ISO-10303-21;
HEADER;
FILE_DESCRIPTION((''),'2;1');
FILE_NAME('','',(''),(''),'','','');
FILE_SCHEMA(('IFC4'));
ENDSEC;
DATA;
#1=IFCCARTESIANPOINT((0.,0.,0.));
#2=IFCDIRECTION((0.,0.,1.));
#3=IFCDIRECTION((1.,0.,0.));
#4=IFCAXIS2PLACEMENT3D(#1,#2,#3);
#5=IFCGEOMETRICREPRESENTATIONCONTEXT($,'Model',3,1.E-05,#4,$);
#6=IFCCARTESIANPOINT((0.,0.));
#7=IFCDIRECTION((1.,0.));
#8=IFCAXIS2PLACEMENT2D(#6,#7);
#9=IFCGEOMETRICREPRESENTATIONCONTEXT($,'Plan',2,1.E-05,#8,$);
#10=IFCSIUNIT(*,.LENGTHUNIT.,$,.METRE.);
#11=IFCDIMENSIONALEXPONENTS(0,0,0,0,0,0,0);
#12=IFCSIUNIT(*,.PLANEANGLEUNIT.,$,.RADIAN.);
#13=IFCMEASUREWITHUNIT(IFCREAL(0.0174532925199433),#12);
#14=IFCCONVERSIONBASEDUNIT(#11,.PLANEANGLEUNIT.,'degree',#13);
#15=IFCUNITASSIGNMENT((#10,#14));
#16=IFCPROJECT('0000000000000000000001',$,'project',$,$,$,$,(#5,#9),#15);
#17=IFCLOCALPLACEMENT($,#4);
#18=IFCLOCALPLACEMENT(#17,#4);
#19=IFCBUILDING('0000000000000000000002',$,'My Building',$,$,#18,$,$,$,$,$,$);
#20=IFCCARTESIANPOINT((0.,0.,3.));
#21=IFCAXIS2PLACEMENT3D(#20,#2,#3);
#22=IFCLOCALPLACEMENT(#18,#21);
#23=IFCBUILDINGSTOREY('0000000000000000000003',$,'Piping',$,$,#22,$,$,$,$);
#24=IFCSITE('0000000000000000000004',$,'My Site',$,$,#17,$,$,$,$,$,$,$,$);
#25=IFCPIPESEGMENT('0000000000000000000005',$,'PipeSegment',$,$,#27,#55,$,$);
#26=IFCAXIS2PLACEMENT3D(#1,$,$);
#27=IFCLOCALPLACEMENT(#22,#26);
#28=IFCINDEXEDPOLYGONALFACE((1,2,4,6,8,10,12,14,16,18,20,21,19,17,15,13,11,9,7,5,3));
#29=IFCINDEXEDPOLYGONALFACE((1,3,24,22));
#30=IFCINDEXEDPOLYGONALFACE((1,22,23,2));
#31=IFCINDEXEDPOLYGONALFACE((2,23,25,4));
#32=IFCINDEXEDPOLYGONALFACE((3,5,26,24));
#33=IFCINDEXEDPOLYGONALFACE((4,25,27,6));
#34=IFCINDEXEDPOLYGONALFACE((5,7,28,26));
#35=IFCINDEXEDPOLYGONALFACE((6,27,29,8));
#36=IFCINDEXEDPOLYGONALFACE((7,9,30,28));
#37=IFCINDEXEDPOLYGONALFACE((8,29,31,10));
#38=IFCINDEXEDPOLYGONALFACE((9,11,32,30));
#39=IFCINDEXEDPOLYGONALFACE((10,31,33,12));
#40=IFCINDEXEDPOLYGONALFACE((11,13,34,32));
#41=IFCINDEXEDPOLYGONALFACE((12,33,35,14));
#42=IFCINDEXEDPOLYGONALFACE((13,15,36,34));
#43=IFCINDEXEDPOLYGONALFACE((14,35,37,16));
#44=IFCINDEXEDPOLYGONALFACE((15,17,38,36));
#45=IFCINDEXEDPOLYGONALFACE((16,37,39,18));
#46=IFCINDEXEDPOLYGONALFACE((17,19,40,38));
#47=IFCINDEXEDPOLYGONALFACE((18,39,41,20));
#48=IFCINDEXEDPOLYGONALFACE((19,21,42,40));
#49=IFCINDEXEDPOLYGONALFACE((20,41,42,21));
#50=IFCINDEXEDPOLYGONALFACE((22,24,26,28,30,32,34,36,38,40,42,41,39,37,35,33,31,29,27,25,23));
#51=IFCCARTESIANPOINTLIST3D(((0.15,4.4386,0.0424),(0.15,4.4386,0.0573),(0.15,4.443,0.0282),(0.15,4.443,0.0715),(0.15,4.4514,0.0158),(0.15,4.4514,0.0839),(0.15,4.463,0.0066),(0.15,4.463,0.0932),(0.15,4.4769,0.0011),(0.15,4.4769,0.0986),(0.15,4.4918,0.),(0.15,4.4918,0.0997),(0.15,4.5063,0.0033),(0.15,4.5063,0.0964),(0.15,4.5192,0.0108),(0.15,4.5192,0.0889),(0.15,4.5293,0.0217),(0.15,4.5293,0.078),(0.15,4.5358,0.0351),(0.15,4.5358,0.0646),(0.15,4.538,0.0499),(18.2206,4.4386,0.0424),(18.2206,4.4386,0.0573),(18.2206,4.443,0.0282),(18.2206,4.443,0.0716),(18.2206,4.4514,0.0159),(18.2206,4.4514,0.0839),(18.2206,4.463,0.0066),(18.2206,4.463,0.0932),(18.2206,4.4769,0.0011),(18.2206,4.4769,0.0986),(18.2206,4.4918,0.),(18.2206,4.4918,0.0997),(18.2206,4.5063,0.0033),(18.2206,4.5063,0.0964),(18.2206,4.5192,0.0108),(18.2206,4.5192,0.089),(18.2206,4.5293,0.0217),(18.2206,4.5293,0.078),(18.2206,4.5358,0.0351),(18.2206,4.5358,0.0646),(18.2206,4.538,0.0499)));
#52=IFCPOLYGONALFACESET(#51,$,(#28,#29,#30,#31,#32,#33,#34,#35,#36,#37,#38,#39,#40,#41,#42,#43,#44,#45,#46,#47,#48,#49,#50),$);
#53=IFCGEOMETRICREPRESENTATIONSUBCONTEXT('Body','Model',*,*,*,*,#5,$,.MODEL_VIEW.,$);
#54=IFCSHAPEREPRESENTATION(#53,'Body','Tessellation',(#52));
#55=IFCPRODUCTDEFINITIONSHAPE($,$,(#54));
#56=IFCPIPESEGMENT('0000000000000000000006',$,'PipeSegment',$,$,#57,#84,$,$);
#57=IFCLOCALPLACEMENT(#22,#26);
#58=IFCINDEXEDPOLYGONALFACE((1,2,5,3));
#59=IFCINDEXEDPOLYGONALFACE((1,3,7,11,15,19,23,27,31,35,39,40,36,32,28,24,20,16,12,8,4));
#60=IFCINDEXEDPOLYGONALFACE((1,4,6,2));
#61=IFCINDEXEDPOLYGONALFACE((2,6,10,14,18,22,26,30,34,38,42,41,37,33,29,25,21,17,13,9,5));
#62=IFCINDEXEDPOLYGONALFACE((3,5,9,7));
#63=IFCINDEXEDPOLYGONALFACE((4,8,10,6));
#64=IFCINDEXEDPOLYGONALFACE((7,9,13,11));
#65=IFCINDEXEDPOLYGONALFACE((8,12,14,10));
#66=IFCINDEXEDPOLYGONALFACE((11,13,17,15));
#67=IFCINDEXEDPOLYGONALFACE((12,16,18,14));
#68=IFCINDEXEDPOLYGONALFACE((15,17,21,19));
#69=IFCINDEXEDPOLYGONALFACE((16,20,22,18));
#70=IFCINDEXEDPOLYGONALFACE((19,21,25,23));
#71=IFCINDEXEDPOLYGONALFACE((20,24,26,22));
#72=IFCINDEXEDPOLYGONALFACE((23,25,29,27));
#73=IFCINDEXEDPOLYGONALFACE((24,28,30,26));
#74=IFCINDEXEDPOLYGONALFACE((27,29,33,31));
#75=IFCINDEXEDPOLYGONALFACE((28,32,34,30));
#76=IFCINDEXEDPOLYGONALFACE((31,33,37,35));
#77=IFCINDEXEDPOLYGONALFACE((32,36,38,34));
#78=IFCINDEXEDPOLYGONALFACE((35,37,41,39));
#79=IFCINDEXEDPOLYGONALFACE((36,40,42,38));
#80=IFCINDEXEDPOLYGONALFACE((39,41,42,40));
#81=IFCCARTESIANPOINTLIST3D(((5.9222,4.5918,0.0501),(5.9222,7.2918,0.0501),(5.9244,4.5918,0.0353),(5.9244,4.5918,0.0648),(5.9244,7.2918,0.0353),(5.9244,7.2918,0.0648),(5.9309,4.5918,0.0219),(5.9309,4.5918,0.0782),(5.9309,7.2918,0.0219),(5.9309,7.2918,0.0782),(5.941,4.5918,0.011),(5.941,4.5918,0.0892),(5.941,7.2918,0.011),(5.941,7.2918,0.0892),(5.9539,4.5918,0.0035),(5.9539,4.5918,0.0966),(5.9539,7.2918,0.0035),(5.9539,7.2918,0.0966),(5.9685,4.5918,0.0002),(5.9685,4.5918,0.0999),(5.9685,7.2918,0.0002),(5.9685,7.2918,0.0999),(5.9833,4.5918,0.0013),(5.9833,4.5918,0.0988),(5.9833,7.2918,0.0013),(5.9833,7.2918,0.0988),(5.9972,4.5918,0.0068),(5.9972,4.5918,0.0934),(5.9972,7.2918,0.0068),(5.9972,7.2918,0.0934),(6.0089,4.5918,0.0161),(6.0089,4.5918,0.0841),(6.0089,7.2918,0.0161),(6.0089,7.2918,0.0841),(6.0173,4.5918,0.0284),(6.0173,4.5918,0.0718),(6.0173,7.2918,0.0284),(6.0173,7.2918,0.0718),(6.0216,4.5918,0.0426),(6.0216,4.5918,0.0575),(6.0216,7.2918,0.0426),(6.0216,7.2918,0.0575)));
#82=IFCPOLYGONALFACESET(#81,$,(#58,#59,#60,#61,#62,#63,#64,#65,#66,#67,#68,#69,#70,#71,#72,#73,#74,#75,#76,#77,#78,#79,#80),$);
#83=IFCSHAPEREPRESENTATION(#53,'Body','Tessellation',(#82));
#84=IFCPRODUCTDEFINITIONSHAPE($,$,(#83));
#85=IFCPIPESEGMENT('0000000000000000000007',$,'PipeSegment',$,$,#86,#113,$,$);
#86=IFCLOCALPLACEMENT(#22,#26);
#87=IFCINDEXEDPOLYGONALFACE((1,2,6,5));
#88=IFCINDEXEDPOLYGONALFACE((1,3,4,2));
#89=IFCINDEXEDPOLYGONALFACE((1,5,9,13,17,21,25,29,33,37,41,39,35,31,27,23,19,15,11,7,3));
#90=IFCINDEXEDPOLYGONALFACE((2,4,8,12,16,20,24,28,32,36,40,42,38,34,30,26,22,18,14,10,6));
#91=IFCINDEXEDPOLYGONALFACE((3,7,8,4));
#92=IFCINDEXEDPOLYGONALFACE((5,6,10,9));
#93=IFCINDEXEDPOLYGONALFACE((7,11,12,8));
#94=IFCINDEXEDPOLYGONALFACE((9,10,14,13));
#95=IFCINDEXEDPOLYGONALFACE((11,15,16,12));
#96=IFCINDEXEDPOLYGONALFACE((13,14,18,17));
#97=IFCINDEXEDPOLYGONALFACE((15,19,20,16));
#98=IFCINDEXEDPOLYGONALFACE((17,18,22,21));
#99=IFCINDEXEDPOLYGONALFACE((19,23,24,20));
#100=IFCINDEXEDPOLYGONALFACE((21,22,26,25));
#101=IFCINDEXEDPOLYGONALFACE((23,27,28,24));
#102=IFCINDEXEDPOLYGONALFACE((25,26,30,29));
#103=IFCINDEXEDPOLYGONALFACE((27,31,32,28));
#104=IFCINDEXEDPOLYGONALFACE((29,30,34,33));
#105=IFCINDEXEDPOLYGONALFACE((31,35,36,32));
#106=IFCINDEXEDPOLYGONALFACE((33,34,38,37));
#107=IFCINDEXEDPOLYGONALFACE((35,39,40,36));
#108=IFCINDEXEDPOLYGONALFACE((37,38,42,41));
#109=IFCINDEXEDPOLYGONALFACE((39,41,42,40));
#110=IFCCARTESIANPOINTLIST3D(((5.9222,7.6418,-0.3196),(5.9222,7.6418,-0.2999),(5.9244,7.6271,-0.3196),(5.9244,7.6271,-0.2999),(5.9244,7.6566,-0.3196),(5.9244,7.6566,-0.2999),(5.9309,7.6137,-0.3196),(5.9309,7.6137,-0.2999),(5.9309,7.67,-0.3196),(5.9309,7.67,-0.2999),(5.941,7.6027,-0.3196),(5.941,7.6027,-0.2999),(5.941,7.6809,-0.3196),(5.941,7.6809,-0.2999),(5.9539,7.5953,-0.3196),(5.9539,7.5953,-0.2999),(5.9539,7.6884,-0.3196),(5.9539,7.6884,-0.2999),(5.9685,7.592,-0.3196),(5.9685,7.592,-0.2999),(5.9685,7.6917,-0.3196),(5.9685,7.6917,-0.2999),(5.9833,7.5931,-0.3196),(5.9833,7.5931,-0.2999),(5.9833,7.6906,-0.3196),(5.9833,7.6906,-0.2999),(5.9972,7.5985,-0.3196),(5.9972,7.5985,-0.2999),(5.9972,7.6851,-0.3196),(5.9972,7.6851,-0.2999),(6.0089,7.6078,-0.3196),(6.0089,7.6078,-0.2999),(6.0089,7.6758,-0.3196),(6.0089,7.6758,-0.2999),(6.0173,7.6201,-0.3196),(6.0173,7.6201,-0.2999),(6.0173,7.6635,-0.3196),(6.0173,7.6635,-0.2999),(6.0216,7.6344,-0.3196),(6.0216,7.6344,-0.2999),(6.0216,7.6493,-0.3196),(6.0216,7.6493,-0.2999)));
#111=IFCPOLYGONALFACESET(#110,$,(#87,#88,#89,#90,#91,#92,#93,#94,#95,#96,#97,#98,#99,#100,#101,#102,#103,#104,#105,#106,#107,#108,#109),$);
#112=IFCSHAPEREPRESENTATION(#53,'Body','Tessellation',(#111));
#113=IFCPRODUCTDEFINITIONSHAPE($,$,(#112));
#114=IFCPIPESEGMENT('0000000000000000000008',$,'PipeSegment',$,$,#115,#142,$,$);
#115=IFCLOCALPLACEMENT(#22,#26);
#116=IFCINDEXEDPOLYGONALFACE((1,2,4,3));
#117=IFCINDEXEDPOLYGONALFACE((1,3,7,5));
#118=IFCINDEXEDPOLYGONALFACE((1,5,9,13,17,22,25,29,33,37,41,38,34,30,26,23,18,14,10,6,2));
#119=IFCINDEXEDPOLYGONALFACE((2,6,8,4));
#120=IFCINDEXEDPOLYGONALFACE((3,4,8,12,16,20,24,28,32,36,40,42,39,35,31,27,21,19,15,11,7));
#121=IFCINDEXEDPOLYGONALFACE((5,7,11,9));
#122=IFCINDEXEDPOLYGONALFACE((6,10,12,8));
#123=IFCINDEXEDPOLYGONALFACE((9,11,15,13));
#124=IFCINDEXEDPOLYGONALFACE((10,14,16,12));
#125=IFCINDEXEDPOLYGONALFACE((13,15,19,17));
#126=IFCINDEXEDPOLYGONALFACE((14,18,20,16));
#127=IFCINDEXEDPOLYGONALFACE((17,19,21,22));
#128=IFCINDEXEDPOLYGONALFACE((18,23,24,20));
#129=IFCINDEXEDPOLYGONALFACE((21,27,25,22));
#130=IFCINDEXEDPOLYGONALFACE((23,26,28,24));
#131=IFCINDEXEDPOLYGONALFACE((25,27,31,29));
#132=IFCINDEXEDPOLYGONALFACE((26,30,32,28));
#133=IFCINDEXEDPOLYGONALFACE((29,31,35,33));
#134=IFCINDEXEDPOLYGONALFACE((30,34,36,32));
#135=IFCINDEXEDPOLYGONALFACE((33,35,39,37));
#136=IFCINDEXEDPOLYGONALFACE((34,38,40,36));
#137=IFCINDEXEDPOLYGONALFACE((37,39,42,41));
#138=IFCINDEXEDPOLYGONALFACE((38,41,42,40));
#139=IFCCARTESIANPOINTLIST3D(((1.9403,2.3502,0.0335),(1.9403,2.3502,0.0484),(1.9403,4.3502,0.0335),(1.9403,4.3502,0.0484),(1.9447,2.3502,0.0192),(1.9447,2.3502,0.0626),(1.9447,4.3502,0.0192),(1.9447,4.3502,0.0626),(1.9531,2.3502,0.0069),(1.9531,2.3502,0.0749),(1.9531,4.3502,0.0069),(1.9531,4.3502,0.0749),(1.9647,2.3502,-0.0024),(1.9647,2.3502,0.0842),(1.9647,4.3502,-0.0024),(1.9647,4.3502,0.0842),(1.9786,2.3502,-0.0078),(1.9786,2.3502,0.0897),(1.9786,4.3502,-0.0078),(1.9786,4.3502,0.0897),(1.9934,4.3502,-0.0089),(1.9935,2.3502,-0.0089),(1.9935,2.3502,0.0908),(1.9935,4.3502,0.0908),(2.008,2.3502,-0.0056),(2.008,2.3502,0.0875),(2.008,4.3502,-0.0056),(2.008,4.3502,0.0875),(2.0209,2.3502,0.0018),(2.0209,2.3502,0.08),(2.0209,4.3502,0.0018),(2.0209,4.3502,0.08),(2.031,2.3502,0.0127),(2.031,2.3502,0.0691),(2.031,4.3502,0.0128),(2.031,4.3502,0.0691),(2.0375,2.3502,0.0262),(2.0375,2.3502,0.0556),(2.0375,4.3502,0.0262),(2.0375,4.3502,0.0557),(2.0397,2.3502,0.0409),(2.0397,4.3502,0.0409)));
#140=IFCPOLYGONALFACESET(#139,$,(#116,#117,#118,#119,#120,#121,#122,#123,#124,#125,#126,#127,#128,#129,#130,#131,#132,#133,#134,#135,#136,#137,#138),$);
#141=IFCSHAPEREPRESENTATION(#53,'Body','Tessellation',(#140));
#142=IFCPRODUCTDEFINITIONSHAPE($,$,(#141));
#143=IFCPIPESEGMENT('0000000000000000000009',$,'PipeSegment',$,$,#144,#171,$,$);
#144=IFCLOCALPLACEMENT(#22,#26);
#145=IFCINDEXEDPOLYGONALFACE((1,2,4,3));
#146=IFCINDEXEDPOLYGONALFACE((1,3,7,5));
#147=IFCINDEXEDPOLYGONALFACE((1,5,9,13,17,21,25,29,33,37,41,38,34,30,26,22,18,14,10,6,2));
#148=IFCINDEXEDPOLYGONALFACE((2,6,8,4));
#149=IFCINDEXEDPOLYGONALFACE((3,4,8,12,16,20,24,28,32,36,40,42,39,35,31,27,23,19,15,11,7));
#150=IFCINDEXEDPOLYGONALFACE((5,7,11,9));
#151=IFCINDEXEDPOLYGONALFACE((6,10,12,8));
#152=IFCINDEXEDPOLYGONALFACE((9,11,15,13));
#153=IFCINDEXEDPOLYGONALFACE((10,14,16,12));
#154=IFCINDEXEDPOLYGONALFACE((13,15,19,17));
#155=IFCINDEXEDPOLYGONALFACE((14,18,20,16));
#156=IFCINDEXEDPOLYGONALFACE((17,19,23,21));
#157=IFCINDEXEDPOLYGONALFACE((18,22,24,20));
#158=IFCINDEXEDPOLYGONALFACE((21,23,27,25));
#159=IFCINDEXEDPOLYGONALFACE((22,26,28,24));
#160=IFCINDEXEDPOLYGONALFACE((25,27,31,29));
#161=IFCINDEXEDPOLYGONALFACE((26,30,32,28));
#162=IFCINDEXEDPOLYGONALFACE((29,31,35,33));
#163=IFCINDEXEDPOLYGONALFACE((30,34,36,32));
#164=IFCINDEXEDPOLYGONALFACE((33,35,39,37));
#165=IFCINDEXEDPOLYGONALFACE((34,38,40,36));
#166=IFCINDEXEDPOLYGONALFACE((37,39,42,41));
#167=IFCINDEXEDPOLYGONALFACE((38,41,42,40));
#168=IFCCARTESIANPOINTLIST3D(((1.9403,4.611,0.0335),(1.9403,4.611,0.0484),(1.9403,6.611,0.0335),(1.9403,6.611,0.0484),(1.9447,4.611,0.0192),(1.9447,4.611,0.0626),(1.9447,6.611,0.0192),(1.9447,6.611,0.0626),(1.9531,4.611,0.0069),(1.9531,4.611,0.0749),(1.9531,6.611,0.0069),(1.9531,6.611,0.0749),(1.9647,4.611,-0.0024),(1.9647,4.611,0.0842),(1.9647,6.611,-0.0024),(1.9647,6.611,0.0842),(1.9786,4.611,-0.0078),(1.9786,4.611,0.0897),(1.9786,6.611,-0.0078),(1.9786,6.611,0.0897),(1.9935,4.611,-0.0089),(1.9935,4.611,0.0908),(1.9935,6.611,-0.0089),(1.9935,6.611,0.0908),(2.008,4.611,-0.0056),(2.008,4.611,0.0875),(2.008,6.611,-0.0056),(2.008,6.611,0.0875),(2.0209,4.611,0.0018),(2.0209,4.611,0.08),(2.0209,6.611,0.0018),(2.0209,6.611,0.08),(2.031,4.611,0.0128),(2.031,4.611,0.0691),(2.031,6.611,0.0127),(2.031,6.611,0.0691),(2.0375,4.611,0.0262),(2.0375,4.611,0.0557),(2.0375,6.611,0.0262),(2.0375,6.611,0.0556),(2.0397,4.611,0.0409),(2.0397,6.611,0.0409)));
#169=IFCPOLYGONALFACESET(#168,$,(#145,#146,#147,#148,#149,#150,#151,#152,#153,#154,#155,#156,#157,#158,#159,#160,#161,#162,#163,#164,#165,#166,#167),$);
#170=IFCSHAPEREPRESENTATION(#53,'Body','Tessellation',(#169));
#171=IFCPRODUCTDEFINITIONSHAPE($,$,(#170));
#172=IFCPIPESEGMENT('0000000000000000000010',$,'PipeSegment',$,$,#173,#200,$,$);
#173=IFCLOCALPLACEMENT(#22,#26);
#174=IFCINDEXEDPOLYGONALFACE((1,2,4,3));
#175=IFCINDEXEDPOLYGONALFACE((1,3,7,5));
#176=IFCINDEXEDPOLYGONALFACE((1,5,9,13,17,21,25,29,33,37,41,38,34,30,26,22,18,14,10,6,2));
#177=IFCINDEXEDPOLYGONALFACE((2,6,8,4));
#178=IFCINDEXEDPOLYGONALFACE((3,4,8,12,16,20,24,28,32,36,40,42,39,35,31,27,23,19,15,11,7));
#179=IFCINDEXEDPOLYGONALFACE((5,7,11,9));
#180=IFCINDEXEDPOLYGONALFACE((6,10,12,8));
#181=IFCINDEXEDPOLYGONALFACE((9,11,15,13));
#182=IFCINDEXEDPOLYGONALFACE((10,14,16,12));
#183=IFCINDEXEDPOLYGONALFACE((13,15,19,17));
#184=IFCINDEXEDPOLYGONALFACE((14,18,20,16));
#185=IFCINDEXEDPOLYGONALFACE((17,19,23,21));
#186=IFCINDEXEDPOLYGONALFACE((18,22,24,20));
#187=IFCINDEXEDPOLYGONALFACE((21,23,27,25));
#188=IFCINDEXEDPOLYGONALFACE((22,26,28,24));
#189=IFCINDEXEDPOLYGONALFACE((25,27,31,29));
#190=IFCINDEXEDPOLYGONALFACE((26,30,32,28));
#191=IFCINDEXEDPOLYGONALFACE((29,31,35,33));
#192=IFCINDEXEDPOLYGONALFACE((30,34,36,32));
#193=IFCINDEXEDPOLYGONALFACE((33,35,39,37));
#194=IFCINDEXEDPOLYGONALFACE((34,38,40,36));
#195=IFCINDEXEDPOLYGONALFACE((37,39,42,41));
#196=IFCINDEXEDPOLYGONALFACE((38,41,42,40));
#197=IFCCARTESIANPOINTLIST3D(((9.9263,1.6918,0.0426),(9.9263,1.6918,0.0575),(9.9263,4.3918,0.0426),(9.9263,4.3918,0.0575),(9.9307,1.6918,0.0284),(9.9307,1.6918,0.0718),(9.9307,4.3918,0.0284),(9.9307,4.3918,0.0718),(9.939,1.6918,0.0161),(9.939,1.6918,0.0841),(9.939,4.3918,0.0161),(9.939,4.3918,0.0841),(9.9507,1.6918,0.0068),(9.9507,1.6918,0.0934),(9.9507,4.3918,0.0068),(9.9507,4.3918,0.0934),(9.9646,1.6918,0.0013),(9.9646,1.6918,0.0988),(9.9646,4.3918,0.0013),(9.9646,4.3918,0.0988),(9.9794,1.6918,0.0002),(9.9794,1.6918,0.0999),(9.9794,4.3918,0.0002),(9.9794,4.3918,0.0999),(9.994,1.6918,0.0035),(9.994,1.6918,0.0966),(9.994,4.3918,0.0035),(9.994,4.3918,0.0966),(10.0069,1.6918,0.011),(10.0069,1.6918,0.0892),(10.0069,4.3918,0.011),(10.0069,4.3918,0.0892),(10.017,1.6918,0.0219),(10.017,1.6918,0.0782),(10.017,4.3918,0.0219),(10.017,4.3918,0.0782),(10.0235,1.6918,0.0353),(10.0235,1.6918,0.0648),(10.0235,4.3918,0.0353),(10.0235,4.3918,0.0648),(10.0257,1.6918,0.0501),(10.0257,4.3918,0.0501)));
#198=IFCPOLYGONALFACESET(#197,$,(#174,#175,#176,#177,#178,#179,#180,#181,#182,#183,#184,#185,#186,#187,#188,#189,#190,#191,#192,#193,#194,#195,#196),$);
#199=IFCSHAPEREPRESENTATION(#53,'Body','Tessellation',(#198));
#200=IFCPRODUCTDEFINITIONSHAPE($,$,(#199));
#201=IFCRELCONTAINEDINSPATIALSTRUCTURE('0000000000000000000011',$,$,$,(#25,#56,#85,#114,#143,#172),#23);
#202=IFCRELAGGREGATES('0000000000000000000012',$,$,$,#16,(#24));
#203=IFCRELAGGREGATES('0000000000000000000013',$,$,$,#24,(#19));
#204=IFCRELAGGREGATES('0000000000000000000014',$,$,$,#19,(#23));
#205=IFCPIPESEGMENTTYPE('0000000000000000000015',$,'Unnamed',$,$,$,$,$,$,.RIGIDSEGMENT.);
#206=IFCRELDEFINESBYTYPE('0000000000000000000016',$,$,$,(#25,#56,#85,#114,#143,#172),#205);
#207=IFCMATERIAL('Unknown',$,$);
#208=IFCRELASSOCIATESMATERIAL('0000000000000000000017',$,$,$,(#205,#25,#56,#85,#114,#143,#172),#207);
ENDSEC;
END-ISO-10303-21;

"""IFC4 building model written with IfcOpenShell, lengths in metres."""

from ifc_helpers import new_model, entity, si_unit, converted_unit, frame, origin_with_axes, origin_2d_with_axis, place, context, subcontext, project, spatial, circle, extrude, material, material_profile, profile_set, profile_usage, type_object, element, save


model = new_model("IFC4")

# Units and contexts
model_context = context("Model", 3, precision=1e-05, world=origin_with_axes())
plan_context = context("Plan", 2, precision=1e-05, world=origin_2d_with_axis())
body_context = subcontext(model_context, "Body", "Model", "MODEL_VIEW")
ifc_project = project(units=[si_unit("LENGTHUNIT", "METRE"), converted_unit("PLANEANGLEUNIT", "degree", entity("IfcReal", 0.0174532925199433), si_unit("PLANEANGLEUNIT", "RADIAN"), dimensions=[0, 0, 0, 0, 0, 0, 0])], contexts=[model_context, plan_context])

# Site, building, storey
site_placement = place(None, origin_with_axes())
site = spatial("IfcSite", under=ifc_project, at=site_placement, Name="My Site")
building_placement = place(site_placement, origin_with_axes())
building = spatial("IfcBuilding", under=site, at=building_placement, Name="My Building")
storey_placement = place(building_placement, frame((0.0, 0.0, 3.0), z_axis=(0.0, 0.0, 1.0), x_axis=(1.0, 0.0, 0.0)))
storey = spatial("IfcBuildingStorey", under=building, at=storey_placement, Name="Piping")

# Pipe segments
ifc_material = material(Name="Unknown")
ifc_material_profile_1 = material_profile(ifc_material, circle(Radius=0.05))
ifc_profile_set_1 = profile_set([ifc_material_profile_1])
ifc_profile_usage_1 = profile_usage(ifc_profile_set_1, cardinal=5)
pipe_segment_type = type_object("IfcPipeSegmentType", Name="Unnamed", PredefinedType="RIGIDSEGMENT", material=ifc_profile_set_1)
pipe_segment_1_placement = place(storey_placement, frame((0.15, 4.488, 0.0499), z_axis=(1.0, 0.0, 0.0), x_axis=(0.0, 1.0, 0.0)))
element("IfcPipeSegment", 1, at=pipe_segment_1_placement, inside=storey, type_object=pipe_segment_type, material=ifc_profile_usage_1, Name="PipeSegment", context=body_context, shape_type="SweptSolid", body=[
    extrude(circle(Radius=0.05), origin_with_axes(), (0.0, 0.0, 1.0), 18.0706),
])
ifc_profile_usage_2 = profile_usage(ifc_profile_set_1, cardinal=5)
pipe_segment_2_placement = place(storey_placement, frame((5.9722, 4.5918, 0.0501), z_axis=(0.0, 1.0, 0.0), x_axis=(-1.0, 0.0, 0.0)))
element("IfcPipeSegment", 2, at=pipe_segment_2_placement, inside=storey, type_object=pipe_segment_type, material=ifc_profile_usage_2, Name="PipeSegment", context=body_context, shape_type="SweptSolid", body=[
    extrude(circle(Radius=0.05), origin_with_axes(), (0.0, 0.0, 1.0), 2.7),
])
ifc_profile_usage_3 = profile_usage(ifc_profile_set_1, cardinal=15)
pipe_segment_3_placement = place(storey_placement, frame((5.9722, 7.6418, -0.2999), z_axis=(0.0, 0.0, -1.0), x_axis=(-1.0, 0.0, 0.0)))
element("IfcPipeSegment", 3, at=pipe_segment_3_placement, inside=storey, type_object=pipe_segment_type, material=ifc_profile_usage_3, Name="PipeSegment", context=body_context, shape_type="SweptSolid", body=[
    extrude(circle(Radius=0.05), origin_with_axes(), (0.0, 0.0, 1.0), 0.0196),
])
ifc_profile_usage_4 = profile_usage(ifc_profile_set_1, cardinal=15)
pipe_segment_4_placement = place(storey_placement, frame((1.9897, 2.3502, 0.0409), z_axis=(0.0, 1.0, 0.000005), x_axis=(1.0, 0.0, -0.000001)))
element("IfcPipeSegment", 4, at=pipe_segment_4_placement, inside=storey, type_object=pipe_segment_type, material=ifc_profile_usage_4, Name="PipeSegment", context=body_context, shape_type="SweptSolid", body=[
    extrude(circle(Radius=0.05), origin_with_axes(), (0.0, 0.0, 1.0), 2.0),
])
ifc_profile_usage_5 = profile_usage(ifc_profile_set_1, cardinal=15)
pipe_segment_5_placement = place(storey_placement, frame((1.9897, 6.611, 0.0409), z_axis=(0.0, -1.0, 0.000005), x_axis=(1.0, 0.0, 0.0)))
element("IfcPipeSegment", 5, at=pipe_segment_5_placement, inside=storey, type_object=pipe_segment_type, material=ifc_profile_usage_5, Name="PipeSegment", context=body_context, shape_type="SweptSolid", body=[
    extrude(circle(Radius=0.05), origin_with_axes(), (0.0, 0.0, 1.0), 2.0),
])
ifc_profile_usage_6 = profile_usage(ifc_profile_set_1, cardinal=5)
pipe_segment_6_placement = place(storey_placement, frame((9.9757, 4.3918, 0.0501), z_axis=(0.0, -1.0, 0.0), x_axis=(1.0, 0.0, 0.0)))
element("IfcPipeSegment", 6, at=pipe_segment_6_placement, inside=storey, type_object=pipe_segment_type, material=ifc_profile_usage_6, Name="PipeSegment", context=body_context, shape_type="SweptSolid", body=[
    extrude(circle(Radius=0.05), origin_with_axes(), (0.0, 0.0, 1.0), 2.7),
])

save(model, "model.ifc")
